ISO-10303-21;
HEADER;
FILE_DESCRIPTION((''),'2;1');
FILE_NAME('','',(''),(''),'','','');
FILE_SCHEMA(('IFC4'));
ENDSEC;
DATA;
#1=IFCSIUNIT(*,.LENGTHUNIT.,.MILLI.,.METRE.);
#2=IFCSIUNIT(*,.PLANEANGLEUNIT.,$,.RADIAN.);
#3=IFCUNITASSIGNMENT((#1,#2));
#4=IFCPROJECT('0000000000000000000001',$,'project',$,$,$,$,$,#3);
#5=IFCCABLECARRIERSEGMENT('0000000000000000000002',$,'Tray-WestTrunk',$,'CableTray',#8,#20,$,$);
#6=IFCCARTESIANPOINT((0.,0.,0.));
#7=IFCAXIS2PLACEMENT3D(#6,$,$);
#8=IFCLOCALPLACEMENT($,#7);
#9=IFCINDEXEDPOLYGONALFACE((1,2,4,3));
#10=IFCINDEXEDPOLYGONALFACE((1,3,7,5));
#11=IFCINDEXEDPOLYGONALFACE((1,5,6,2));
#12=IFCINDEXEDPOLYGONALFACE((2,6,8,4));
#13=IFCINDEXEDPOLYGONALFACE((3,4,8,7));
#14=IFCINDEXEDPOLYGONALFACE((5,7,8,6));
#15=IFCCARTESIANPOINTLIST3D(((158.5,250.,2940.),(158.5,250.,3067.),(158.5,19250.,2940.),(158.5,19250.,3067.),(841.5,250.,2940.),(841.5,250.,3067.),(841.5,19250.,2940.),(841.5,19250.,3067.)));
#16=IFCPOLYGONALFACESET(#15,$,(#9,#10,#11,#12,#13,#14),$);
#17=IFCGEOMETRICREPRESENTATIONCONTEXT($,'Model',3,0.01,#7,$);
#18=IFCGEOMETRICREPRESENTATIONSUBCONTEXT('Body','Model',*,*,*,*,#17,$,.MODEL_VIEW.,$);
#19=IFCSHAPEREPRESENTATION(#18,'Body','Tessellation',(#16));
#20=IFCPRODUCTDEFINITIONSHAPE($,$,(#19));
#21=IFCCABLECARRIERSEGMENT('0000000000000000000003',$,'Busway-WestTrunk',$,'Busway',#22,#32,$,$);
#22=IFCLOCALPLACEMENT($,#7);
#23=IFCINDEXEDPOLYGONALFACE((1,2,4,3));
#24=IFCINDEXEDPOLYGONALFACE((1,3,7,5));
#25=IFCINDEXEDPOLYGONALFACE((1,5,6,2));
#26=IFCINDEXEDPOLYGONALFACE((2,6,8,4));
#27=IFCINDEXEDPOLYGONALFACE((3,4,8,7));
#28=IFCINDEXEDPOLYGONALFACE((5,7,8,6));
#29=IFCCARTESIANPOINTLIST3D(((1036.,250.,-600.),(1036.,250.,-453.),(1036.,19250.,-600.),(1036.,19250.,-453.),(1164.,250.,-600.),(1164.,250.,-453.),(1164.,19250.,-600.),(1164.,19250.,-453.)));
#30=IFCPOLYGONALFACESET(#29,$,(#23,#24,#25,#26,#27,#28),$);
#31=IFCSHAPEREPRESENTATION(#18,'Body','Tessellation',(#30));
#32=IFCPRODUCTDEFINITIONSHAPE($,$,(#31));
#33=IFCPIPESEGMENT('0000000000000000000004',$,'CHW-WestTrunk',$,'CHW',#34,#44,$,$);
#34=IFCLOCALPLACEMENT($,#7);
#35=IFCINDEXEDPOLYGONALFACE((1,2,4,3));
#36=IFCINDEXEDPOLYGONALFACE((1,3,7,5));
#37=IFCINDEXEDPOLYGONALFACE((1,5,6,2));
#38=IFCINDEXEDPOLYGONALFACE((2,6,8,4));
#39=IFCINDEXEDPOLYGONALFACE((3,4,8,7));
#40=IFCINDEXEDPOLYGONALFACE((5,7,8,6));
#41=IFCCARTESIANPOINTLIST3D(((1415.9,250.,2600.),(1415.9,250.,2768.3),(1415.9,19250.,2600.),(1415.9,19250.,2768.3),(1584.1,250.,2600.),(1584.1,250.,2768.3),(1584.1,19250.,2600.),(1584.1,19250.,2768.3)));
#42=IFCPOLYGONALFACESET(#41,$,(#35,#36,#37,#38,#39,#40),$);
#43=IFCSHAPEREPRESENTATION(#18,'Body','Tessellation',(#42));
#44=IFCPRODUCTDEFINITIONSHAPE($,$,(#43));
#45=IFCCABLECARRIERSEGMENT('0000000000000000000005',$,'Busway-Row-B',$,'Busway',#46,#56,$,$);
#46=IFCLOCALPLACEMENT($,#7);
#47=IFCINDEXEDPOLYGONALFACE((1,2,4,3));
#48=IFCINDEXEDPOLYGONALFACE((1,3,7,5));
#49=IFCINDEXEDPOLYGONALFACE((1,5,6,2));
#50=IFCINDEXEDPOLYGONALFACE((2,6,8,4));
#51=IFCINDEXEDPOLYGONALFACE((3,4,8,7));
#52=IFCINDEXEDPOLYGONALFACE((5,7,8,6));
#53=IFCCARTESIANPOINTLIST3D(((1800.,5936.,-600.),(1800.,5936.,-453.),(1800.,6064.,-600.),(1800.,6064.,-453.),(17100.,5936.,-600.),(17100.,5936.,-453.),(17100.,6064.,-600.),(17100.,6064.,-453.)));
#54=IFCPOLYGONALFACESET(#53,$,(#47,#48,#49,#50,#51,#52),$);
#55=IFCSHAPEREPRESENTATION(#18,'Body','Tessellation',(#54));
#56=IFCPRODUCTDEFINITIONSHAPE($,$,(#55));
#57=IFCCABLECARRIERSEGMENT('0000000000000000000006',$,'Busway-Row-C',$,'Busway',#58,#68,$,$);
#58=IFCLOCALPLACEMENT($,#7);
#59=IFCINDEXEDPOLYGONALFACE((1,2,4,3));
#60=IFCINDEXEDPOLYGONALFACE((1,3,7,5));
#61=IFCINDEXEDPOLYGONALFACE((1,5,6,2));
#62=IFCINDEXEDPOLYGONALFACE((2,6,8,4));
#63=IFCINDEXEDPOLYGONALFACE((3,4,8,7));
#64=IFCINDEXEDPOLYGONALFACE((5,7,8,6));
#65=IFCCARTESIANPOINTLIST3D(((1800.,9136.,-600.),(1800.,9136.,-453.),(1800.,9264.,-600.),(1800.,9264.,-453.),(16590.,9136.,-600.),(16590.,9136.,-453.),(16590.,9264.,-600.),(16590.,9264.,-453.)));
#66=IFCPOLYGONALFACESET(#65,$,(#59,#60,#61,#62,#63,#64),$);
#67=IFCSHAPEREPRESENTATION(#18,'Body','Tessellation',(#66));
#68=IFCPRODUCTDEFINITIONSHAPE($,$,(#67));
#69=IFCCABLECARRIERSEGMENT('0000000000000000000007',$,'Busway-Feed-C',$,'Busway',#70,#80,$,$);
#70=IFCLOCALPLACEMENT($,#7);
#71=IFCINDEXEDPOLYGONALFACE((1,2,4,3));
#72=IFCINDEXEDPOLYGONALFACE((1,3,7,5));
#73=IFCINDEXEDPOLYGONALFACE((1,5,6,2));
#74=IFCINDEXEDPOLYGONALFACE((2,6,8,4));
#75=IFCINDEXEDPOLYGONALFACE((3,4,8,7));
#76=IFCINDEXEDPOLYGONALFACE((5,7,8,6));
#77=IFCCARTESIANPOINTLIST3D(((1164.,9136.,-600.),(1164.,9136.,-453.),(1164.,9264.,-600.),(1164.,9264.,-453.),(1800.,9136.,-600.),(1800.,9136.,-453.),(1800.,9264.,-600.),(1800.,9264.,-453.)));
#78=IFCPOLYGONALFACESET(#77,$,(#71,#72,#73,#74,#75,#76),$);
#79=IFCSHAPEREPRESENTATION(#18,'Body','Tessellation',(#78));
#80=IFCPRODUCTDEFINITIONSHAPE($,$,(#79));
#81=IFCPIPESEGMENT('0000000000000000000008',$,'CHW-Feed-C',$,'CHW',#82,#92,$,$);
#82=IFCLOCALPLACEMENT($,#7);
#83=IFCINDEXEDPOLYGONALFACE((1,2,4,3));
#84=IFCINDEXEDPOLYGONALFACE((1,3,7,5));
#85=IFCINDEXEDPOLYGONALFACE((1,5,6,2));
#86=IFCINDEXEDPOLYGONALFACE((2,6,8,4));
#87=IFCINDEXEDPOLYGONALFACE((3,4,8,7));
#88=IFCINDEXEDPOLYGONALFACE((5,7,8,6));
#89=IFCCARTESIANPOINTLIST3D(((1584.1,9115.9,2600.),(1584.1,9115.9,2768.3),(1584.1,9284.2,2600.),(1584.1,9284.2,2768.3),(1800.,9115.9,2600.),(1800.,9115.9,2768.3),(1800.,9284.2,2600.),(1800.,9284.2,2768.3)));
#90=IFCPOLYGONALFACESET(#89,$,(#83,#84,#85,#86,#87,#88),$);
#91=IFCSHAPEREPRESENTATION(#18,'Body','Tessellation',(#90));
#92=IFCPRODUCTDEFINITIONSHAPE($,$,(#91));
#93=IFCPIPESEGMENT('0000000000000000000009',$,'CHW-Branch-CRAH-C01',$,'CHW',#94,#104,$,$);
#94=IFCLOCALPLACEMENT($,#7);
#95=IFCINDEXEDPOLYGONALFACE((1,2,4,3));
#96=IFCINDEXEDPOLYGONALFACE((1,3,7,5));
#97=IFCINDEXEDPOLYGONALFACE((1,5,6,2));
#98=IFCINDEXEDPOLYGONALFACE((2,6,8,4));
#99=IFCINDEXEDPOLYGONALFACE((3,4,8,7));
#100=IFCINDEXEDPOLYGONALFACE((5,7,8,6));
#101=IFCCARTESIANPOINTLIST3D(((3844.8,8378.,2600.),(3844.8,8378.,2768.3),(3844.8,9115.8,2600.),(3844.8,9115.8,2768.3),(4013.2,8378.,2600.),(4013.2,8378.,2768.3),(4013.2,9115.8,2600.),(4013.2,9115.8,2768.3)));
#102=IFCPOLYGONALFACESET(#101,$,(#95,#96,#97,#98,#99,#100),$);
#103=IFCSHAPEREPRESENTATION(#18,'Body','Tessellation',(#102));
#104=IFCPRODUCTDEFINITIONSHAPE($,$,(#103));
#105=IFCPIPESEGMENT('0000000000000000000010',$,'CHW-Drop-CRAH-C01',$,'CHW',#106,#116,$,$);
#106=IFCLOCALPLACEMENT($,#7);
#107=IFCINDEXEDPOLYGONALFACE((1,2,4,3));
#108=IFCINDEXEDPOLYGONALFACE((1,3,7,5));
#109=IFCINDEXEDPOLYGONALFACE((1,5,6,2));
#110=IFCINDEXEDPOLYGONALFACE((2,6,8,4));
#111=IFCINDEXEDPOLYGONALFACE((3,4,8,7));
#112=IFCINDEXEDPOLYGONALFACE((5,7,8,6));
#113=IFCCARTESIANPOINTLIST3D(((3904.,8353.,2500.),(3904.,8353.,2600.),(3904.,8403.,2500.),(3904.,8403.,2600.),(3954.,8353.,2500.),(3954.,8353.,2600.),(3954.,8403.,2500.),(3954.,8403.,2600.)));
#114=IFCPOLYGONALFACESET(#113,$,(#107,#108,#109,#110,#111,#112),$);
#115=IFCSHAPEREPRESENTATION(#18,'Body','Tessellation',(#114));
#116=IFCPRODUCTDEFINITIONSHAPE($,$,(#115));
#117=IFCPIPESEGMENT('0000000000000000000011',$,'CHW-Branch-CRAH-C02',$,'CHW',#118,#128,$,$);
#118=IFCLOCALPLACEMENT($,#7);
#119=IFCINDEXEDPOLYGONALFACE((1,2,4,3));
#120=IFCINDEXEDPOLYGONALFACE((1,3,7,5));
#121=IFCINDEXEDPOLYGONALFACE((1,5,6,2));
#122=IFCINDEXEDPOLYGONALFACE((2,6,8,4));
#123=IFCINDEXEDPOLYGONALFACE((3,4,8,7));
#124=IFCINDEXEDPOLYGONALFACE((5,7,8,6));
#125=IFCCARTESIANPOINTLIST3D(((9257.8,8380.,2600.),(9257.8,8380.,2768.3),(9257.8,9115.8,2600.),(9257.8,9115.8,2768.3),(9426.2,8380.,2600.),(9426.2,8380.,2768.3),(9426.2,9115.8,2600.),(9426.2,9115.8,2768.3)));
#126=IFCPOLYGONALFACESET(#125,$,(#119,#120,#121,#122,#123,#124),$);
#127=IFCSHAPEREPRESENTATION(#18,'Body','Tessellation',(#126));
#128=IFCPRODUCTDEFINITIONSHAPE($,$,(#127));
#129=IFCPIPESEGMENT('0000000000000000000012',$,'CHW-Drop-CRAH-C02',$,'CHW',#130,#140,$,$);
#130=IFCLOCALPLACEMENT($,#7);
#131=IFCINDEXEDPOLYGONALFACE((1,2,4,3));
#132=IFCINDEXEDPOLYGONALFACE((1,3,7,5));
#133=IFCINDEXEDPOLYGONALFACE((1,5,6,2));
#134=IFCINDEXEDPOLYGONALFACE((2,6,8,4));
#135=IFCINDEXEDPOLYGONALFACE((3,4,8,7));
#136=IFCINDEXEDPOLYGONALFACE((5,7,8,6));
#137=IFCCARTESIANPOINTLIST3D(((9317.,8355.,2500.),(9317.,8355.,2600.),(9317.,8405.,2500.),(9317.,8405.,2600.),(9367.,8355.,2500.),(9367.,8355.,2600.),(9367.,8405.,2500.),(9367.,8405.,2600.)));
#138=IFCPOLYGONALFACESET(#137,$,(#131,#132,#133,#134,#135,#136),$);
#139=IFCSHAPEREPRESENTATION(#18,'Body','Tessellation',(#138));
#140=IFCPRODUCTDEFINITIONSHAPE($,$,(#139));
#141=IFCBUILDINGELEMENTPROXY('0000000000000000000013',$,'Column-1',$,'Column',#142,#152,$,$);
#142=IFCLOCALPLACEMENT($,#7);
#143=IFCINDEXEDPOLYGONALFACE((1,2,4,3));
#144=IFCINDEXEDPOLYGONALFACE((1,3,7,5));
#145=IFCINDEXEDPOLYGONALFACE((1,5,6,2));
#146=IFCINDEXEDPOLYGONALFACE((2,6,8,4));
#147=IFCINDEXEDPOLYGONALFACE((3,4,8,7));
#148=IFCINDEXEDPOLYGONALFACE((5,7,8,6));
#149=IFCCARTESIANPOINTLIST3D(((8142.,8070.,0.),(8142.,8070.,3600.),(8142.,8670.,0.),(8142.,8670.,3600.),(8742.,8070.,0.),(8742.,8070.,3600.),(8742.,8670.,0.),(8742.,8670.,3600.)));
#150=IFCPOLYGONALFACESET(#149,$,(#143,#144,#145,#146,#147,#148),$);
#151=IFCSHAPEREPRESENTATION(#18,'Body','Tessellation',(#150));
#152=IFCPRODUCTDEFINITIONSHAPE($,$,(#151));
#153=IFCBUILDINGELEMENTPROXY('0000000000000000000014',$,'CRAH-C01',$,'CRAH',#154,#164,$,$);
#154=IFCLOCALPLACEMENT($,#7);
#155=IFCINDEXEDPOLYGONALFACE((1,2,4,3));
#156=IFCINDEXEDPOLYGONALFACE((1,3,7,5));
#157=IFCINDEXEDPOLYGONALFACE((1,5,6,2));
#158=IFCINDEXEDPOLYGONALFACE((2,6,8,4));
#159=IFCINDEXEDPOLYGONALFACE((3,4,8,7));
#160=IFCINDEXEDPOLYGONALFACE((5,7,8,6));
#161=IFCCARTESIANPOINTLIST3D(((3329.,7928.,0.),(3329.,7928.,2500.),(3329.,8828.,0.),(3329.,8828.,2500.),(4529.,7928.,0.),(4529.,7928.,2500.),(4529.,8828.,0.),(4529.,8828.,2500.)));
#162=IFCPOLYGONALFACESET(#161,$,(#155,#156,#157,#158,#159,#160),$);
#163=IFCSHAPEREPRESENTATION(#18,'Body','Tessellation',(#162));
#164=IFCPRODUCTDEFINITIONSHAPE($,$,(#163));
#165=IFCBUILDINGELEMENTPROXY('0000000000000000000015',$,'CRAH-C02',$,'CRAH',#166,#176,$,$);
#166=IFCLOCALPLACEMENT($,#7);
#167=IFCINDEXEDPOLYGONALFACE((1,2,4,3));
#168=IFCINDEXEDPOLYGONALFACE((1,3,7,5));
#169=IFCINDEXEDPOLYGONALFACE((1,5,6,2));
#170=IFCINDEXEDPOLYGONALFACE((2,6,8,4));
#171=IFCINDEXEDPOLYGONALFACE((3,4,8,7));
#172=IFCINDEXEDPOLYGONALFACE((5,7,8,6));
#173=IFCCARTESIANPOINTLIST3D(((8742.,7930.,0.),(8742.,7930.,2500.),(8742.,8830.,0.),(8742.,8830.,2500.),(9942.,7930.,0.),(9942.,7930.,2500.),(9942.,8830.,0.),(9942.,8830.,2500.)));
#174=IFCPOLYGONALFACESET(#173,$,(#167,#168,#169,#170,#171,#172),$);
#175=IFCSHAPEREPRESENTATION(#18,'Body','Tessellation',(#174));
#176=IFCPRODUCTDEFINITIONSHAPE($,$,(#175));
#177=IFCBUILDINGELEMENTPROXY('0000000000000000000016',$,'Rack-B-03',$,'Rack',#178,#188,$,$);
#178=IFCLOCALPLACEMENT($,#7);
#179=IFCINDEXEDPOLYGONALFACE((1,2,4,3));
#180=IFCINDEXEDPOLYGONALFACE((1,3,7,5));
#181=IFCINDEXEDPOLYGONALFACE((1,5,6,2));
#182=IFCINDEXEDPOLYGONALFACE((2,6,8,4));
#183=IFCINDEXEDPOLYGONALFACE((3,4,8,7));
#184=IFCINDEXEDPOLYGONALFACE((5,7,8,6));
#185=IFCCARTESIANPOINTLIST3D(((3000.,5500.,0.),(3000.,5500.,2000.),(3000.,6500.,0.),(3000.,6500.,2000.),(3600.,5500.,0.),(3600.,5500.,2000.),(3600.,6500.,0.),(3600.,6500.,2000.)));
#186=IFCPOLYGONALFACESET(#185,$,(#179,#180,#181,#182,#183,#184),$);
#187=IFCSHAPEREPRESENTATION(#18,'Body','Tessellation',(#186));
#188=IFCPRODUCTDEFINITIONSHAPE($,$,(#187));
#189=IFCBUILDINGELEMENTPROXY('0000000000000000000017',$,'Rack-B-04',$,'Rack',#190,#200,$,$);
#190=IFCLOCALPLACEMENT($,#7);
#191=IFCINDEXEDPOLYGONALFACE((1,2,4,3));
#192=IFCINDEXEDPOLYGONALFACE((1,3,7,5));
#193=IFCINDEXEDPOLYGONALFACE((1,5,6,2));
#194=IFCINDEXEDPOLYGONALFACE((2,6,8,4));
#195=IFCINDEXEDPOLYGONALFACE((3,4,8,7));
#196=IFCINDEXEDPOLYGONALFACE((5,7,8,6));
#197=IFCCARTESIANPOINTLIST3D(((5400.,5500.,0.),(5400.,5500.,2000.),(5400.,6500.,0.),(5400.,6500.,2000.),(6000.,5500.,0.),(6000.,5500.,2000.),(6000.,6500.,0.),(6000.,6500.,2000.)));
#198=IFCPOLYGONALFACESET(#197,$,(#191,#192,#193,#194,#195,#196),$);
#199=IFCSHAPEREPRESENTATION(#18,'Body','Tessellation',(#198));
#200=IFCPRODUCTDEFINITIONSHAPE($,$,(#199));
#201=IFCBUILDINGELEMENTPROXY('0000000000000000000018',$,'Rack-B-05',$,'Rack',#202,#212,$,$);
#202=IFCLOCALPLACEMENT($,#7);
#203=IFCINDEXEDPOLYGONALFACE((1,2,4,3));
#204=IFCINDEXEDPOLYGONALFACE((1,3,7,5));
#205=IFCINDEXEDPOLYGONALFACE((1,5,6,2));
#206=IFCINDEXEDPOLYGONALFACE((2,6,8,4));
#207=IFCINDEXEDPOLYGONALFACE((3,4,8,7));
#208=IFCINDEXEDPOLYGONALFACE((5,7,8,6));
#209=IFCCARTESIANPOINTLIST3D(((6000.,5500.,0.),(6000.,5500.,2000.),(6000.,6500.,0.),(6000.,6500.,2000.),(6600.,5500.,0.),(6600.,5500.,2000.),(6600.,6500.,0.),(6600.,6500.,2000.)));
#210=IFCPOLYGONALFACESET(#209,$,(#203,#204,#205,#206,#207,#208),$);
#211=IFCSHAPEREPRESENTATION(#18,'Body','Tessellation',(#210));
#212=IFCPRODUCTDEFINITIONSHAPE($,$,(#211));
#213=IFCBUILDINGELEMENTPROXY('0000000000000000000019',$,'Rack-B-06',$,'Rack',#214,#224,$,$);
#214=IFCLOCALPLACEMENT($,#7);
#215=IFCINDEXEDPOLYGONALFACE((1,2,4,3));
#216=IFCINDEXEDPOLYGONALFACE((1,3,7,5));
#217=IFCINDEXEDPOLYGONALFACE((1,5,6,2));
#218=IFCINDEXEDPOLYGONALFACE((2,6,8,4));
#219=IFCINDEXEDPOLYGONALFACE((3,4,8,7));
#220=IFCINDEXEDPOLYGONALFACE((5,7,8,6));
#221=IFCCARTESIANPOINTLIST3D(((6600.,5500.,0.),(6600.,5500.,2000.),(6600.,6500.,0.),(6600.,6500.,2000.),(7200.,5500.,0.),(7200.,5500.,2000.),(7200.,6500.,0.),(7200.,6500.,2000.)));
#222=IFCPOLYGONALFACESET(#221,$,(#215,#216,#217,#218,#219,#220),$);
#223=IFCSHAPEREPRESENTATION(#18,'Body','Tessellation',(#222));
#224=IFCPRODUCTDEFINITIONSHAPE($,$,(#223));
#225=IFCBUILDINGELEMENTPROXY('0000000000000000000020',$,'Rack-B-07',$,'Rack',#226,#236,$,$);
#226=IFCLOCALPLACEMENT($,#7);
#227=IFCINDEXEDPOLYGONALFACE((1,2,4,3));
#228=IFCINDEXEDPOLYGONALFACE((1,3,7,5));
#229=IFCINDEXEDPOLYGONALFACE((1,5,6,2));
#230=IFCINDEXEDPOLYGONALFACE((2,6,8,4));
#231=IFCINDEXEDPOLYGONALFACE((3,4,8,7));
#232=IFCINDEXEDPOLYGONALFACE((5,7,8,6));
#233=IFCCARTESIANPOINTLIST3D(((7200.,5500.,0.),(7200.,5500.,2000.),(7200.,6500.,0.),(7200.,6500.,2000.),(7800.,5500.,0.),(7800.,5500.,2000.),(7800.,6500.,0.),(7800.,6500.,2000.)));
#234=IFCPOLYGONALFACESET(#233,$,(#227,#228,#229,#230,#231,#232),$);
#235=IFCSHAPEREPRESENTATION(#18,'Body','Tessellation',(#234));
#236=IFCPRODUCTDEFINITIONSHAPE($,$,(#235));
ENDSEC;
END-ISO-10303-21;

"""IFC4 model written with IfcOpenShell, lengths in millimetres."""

from ifc_helpers import new_model, si_unit, frame, origin, place, context, subcontext, project, rectangle, extrude, element, save


model = new_model("IFC4")

# Units and contexts
model_context = context("Model", 3, precision=0.01, world=origin())
body_context = subcontext(model_context, "Body", "Model", "MODEL_VIEW")
ifc_project = project(units=[si_unit("LENGTHUNIT", "METRE", prefix="MILLI"), si_unit("PLANEANGLEUNIT", "RADIAN")])

# Cable carrier segments
placement = place(None, origin())
cable_carrier_segment_1_placement = place(placement, frame((500.0, 9750.0, 2940.0)))
element("IfcCableCarrierSegment", 1, at=cable_carrier_segment_1_placement, Name="Tray-WestTrunk", ObjectType="CableTray", context=body_context, shape_type="SweptSolid", body=[
    extrude(rectangle(XDim=683.0, YDim=19000.0), origin(), (0.0, 0.0, 1.0), 127.0),
])
cable_carrier_segment_2_placement = place(placement, frame((1100.0, 9750.0, -600.0)))
element("IfcCableCarrierSegment", 2, at=cable_carrier_segment_2_placement, Name="Busway-WestTrunk", ObjectType="Busway", context=body_context, shape_type="SweptSolid", body=[
    extrude(rectangle(XDim=128.0, YDim=19000.0), origin(), (0.0, 0.0, 1.0), 147.0),
])

# Pipe segment
pipe_segment_1_placement = place(placement, frame((1500.0, 9750.0, 2600.0)))
element("IfcPipeSegment", 3, at=pipe_segment_1_placement, Name="CHW-WestTrunk", ObjectType="CHW", context=body_context, shape_type="SweptSolid", body=[
    extrude(rectangle(XDim=168.3, YDim=19000.0), origin(), (0.0, 0.0, 1.0), 168.3),
])

# Cable carrier segments
cable_carrier_segment_3_placement = place(placement, frame((9450.0, 6000.0, -600.0)))
element("IfcCableCarrierSegment", 4, at=cable_carrier_segment_3_placement, Name="Busway-Row-B", ObjectType="Busway", context=body_context, shape_type="SweptSolid", body=[
    extrude(rectangle(XDim=15300.0, YDim=128.0), origin(), (0.0, 0.0, 1.0), 147.0),
])
cable_carrier_segment_4_placement = place(placement, frame((9195.0, 9200.0, -600.0)))
element("IfcCableCarrierSegment", 5, at=cable_carrier_segment_4_placement, Name="Busway-Row-C", ObjectType="Busway", context=body_context, shape_type="SweptSolid", body=[
    extrude(rectangle(XDim=14790.0, YDim=128.0), origin(), (0.0, 0.0, 1.0), 147.0),
])
cable_carrier_segment_5_placement = place(placement, frame((1482.0, 9200.0, -600.0)))
element("IfcCableCarrierSegment", 6, at=cable_carrier_segment_5_placement, Name="Busway-Feed-C", ObjectType="Busway", context=body_context, shape_type="SweptSolid", body=[
    extrude(rectangle(XDim=636.0, YDim=128.0), origin(), (0.0, 0.0, 1.0), 147.0),
])

# Pipe segments
pipe_segment_2_placement = place(placement, frame((1692.1, 9200.0, 2600.0)))
element("IfcPipeSegment", 7, at=pipe_segment_2_placement, Name="CHW-Feed-C", ObjectType="CHW", context=body_context, shape_type="SweptSolid", body=[
    extrude(rectangle(XDim=215.8, YDim=168.3), origin(), (0.0, 0.0, 1.0), 168.3),
])
pipe_segment_3_placement = place(placement, frame((3929.0, 8746.9, 2600.0)))
element("IfcPipeSegment", 8, at=pipe_segment_3_placement, Name="CHW-Branch-CRAH-C01", ObjectType="CHW", context=body_context, shape_type="SweptSolid", body=[
    extrude(rectangle(XDim=168.3, YDim=737.9), origin(), (0.0, 0.0, 1.0), 168.3),
])
pipe_segment_4_placement = place(placement, frame((3929.0, 8378.0, 2500.0)))
element("IfcPipeSegment", 9, at=pipe_segment_4_placement, Name="CHW-Drop-CRAH-C01", ObjectType="CHW", context=body_context, shape_type="SweptSolid", body=[
    extrude(rectangle(XDim=50.0, YDim=50.0), origin(), (0.0, 0.0, 1.0), 100.0),
])
pipe_segment_5_placement = place(placement, frame((9342.0, 8747.9, 2600.0)))
element("IfcPipeSegment", 10, at=pipe_segment_5_placement, Name="CHW-Branch-CRAH-C02", ObjectType="CHW", context=body_context, shape_type="SweptSolid", body=[
    extrude(rectangle(XDim=168.3, YDim=735.9), origin(), (0.0, 0.0, 1.0), 168.3),
])
pipe_segment_6_placement = place(placement, frame((9342.0, 8380.0, 2500.0)))
element("IfcPipeSegment", 11, at=pipe_segment_6_placement, Name="CHW-Drop-CRAH-C02", ObjectType="CHW", context=body_context, shape_type="SweptSolid", body=[
    extrude(rectangle(XDim=50.0, YDim=50.0), origin(), (0.0, 0.0, 1.0), 100.0),
])

# Building element proxies
proxy_placement = place(placement, frame((8442.0, 8370.0, 0.0)))
element("IfcBuildingElementProxy", 12, at=proxy_placement, Name="Column-1", ObjectType="Column", context=body_context, shape_type="SweptSolid", body=[
    extrude(rectangle(XDim=600.0, YDim=600.0), origin(), (0.0, 0.0, 1.0), 3600.0),
])
for number, where, name in (
    (13, (3929.0, 8378.0, 0.0), "CRAH-C01"),
    (14, (9342.0, 8380.0, 0.0), "CRAH-C02"),
):
    element("IfcBuildingElementProxy", number, at=place(placement, frame(where)), Name=name, ObjectType="CRAH", context=body_context, shape_type="SweptSolid", body=[
        extrude(rectangle(XDim=1200.0, YDim=900.0), origin(), (0.0, 0.0, 1.0), 2500.0),
    ])
for number, where, name in (
    (15, (3300.0, 6000.0, 0.0), "Rack-B-03"),
    (16, (5700.0, 6000.0, 0.0), "Rack-B-04"),
    (17, (6300.0, 6000.0, 0.0), "Rack-B-05"),
    (18, (6900.0, 6000.0, 0.0), "Rack-B-06"),
    (19, (7500.0, 6000.0, 0.0), "Rack-B-07"),
):
    element("IfcBuildingElementProxy", number, at=place(placement, frame(where)), Name=name, ObjectType="Rack", context=body_context, shape_type="SweptSolid", body=[
        extrude(rectangle(XDim=600.0, YDim=1000.0), origin(), (0.0, 0.0, 1.0), 2000.0),
    ])

save(model, "model.ifc")
